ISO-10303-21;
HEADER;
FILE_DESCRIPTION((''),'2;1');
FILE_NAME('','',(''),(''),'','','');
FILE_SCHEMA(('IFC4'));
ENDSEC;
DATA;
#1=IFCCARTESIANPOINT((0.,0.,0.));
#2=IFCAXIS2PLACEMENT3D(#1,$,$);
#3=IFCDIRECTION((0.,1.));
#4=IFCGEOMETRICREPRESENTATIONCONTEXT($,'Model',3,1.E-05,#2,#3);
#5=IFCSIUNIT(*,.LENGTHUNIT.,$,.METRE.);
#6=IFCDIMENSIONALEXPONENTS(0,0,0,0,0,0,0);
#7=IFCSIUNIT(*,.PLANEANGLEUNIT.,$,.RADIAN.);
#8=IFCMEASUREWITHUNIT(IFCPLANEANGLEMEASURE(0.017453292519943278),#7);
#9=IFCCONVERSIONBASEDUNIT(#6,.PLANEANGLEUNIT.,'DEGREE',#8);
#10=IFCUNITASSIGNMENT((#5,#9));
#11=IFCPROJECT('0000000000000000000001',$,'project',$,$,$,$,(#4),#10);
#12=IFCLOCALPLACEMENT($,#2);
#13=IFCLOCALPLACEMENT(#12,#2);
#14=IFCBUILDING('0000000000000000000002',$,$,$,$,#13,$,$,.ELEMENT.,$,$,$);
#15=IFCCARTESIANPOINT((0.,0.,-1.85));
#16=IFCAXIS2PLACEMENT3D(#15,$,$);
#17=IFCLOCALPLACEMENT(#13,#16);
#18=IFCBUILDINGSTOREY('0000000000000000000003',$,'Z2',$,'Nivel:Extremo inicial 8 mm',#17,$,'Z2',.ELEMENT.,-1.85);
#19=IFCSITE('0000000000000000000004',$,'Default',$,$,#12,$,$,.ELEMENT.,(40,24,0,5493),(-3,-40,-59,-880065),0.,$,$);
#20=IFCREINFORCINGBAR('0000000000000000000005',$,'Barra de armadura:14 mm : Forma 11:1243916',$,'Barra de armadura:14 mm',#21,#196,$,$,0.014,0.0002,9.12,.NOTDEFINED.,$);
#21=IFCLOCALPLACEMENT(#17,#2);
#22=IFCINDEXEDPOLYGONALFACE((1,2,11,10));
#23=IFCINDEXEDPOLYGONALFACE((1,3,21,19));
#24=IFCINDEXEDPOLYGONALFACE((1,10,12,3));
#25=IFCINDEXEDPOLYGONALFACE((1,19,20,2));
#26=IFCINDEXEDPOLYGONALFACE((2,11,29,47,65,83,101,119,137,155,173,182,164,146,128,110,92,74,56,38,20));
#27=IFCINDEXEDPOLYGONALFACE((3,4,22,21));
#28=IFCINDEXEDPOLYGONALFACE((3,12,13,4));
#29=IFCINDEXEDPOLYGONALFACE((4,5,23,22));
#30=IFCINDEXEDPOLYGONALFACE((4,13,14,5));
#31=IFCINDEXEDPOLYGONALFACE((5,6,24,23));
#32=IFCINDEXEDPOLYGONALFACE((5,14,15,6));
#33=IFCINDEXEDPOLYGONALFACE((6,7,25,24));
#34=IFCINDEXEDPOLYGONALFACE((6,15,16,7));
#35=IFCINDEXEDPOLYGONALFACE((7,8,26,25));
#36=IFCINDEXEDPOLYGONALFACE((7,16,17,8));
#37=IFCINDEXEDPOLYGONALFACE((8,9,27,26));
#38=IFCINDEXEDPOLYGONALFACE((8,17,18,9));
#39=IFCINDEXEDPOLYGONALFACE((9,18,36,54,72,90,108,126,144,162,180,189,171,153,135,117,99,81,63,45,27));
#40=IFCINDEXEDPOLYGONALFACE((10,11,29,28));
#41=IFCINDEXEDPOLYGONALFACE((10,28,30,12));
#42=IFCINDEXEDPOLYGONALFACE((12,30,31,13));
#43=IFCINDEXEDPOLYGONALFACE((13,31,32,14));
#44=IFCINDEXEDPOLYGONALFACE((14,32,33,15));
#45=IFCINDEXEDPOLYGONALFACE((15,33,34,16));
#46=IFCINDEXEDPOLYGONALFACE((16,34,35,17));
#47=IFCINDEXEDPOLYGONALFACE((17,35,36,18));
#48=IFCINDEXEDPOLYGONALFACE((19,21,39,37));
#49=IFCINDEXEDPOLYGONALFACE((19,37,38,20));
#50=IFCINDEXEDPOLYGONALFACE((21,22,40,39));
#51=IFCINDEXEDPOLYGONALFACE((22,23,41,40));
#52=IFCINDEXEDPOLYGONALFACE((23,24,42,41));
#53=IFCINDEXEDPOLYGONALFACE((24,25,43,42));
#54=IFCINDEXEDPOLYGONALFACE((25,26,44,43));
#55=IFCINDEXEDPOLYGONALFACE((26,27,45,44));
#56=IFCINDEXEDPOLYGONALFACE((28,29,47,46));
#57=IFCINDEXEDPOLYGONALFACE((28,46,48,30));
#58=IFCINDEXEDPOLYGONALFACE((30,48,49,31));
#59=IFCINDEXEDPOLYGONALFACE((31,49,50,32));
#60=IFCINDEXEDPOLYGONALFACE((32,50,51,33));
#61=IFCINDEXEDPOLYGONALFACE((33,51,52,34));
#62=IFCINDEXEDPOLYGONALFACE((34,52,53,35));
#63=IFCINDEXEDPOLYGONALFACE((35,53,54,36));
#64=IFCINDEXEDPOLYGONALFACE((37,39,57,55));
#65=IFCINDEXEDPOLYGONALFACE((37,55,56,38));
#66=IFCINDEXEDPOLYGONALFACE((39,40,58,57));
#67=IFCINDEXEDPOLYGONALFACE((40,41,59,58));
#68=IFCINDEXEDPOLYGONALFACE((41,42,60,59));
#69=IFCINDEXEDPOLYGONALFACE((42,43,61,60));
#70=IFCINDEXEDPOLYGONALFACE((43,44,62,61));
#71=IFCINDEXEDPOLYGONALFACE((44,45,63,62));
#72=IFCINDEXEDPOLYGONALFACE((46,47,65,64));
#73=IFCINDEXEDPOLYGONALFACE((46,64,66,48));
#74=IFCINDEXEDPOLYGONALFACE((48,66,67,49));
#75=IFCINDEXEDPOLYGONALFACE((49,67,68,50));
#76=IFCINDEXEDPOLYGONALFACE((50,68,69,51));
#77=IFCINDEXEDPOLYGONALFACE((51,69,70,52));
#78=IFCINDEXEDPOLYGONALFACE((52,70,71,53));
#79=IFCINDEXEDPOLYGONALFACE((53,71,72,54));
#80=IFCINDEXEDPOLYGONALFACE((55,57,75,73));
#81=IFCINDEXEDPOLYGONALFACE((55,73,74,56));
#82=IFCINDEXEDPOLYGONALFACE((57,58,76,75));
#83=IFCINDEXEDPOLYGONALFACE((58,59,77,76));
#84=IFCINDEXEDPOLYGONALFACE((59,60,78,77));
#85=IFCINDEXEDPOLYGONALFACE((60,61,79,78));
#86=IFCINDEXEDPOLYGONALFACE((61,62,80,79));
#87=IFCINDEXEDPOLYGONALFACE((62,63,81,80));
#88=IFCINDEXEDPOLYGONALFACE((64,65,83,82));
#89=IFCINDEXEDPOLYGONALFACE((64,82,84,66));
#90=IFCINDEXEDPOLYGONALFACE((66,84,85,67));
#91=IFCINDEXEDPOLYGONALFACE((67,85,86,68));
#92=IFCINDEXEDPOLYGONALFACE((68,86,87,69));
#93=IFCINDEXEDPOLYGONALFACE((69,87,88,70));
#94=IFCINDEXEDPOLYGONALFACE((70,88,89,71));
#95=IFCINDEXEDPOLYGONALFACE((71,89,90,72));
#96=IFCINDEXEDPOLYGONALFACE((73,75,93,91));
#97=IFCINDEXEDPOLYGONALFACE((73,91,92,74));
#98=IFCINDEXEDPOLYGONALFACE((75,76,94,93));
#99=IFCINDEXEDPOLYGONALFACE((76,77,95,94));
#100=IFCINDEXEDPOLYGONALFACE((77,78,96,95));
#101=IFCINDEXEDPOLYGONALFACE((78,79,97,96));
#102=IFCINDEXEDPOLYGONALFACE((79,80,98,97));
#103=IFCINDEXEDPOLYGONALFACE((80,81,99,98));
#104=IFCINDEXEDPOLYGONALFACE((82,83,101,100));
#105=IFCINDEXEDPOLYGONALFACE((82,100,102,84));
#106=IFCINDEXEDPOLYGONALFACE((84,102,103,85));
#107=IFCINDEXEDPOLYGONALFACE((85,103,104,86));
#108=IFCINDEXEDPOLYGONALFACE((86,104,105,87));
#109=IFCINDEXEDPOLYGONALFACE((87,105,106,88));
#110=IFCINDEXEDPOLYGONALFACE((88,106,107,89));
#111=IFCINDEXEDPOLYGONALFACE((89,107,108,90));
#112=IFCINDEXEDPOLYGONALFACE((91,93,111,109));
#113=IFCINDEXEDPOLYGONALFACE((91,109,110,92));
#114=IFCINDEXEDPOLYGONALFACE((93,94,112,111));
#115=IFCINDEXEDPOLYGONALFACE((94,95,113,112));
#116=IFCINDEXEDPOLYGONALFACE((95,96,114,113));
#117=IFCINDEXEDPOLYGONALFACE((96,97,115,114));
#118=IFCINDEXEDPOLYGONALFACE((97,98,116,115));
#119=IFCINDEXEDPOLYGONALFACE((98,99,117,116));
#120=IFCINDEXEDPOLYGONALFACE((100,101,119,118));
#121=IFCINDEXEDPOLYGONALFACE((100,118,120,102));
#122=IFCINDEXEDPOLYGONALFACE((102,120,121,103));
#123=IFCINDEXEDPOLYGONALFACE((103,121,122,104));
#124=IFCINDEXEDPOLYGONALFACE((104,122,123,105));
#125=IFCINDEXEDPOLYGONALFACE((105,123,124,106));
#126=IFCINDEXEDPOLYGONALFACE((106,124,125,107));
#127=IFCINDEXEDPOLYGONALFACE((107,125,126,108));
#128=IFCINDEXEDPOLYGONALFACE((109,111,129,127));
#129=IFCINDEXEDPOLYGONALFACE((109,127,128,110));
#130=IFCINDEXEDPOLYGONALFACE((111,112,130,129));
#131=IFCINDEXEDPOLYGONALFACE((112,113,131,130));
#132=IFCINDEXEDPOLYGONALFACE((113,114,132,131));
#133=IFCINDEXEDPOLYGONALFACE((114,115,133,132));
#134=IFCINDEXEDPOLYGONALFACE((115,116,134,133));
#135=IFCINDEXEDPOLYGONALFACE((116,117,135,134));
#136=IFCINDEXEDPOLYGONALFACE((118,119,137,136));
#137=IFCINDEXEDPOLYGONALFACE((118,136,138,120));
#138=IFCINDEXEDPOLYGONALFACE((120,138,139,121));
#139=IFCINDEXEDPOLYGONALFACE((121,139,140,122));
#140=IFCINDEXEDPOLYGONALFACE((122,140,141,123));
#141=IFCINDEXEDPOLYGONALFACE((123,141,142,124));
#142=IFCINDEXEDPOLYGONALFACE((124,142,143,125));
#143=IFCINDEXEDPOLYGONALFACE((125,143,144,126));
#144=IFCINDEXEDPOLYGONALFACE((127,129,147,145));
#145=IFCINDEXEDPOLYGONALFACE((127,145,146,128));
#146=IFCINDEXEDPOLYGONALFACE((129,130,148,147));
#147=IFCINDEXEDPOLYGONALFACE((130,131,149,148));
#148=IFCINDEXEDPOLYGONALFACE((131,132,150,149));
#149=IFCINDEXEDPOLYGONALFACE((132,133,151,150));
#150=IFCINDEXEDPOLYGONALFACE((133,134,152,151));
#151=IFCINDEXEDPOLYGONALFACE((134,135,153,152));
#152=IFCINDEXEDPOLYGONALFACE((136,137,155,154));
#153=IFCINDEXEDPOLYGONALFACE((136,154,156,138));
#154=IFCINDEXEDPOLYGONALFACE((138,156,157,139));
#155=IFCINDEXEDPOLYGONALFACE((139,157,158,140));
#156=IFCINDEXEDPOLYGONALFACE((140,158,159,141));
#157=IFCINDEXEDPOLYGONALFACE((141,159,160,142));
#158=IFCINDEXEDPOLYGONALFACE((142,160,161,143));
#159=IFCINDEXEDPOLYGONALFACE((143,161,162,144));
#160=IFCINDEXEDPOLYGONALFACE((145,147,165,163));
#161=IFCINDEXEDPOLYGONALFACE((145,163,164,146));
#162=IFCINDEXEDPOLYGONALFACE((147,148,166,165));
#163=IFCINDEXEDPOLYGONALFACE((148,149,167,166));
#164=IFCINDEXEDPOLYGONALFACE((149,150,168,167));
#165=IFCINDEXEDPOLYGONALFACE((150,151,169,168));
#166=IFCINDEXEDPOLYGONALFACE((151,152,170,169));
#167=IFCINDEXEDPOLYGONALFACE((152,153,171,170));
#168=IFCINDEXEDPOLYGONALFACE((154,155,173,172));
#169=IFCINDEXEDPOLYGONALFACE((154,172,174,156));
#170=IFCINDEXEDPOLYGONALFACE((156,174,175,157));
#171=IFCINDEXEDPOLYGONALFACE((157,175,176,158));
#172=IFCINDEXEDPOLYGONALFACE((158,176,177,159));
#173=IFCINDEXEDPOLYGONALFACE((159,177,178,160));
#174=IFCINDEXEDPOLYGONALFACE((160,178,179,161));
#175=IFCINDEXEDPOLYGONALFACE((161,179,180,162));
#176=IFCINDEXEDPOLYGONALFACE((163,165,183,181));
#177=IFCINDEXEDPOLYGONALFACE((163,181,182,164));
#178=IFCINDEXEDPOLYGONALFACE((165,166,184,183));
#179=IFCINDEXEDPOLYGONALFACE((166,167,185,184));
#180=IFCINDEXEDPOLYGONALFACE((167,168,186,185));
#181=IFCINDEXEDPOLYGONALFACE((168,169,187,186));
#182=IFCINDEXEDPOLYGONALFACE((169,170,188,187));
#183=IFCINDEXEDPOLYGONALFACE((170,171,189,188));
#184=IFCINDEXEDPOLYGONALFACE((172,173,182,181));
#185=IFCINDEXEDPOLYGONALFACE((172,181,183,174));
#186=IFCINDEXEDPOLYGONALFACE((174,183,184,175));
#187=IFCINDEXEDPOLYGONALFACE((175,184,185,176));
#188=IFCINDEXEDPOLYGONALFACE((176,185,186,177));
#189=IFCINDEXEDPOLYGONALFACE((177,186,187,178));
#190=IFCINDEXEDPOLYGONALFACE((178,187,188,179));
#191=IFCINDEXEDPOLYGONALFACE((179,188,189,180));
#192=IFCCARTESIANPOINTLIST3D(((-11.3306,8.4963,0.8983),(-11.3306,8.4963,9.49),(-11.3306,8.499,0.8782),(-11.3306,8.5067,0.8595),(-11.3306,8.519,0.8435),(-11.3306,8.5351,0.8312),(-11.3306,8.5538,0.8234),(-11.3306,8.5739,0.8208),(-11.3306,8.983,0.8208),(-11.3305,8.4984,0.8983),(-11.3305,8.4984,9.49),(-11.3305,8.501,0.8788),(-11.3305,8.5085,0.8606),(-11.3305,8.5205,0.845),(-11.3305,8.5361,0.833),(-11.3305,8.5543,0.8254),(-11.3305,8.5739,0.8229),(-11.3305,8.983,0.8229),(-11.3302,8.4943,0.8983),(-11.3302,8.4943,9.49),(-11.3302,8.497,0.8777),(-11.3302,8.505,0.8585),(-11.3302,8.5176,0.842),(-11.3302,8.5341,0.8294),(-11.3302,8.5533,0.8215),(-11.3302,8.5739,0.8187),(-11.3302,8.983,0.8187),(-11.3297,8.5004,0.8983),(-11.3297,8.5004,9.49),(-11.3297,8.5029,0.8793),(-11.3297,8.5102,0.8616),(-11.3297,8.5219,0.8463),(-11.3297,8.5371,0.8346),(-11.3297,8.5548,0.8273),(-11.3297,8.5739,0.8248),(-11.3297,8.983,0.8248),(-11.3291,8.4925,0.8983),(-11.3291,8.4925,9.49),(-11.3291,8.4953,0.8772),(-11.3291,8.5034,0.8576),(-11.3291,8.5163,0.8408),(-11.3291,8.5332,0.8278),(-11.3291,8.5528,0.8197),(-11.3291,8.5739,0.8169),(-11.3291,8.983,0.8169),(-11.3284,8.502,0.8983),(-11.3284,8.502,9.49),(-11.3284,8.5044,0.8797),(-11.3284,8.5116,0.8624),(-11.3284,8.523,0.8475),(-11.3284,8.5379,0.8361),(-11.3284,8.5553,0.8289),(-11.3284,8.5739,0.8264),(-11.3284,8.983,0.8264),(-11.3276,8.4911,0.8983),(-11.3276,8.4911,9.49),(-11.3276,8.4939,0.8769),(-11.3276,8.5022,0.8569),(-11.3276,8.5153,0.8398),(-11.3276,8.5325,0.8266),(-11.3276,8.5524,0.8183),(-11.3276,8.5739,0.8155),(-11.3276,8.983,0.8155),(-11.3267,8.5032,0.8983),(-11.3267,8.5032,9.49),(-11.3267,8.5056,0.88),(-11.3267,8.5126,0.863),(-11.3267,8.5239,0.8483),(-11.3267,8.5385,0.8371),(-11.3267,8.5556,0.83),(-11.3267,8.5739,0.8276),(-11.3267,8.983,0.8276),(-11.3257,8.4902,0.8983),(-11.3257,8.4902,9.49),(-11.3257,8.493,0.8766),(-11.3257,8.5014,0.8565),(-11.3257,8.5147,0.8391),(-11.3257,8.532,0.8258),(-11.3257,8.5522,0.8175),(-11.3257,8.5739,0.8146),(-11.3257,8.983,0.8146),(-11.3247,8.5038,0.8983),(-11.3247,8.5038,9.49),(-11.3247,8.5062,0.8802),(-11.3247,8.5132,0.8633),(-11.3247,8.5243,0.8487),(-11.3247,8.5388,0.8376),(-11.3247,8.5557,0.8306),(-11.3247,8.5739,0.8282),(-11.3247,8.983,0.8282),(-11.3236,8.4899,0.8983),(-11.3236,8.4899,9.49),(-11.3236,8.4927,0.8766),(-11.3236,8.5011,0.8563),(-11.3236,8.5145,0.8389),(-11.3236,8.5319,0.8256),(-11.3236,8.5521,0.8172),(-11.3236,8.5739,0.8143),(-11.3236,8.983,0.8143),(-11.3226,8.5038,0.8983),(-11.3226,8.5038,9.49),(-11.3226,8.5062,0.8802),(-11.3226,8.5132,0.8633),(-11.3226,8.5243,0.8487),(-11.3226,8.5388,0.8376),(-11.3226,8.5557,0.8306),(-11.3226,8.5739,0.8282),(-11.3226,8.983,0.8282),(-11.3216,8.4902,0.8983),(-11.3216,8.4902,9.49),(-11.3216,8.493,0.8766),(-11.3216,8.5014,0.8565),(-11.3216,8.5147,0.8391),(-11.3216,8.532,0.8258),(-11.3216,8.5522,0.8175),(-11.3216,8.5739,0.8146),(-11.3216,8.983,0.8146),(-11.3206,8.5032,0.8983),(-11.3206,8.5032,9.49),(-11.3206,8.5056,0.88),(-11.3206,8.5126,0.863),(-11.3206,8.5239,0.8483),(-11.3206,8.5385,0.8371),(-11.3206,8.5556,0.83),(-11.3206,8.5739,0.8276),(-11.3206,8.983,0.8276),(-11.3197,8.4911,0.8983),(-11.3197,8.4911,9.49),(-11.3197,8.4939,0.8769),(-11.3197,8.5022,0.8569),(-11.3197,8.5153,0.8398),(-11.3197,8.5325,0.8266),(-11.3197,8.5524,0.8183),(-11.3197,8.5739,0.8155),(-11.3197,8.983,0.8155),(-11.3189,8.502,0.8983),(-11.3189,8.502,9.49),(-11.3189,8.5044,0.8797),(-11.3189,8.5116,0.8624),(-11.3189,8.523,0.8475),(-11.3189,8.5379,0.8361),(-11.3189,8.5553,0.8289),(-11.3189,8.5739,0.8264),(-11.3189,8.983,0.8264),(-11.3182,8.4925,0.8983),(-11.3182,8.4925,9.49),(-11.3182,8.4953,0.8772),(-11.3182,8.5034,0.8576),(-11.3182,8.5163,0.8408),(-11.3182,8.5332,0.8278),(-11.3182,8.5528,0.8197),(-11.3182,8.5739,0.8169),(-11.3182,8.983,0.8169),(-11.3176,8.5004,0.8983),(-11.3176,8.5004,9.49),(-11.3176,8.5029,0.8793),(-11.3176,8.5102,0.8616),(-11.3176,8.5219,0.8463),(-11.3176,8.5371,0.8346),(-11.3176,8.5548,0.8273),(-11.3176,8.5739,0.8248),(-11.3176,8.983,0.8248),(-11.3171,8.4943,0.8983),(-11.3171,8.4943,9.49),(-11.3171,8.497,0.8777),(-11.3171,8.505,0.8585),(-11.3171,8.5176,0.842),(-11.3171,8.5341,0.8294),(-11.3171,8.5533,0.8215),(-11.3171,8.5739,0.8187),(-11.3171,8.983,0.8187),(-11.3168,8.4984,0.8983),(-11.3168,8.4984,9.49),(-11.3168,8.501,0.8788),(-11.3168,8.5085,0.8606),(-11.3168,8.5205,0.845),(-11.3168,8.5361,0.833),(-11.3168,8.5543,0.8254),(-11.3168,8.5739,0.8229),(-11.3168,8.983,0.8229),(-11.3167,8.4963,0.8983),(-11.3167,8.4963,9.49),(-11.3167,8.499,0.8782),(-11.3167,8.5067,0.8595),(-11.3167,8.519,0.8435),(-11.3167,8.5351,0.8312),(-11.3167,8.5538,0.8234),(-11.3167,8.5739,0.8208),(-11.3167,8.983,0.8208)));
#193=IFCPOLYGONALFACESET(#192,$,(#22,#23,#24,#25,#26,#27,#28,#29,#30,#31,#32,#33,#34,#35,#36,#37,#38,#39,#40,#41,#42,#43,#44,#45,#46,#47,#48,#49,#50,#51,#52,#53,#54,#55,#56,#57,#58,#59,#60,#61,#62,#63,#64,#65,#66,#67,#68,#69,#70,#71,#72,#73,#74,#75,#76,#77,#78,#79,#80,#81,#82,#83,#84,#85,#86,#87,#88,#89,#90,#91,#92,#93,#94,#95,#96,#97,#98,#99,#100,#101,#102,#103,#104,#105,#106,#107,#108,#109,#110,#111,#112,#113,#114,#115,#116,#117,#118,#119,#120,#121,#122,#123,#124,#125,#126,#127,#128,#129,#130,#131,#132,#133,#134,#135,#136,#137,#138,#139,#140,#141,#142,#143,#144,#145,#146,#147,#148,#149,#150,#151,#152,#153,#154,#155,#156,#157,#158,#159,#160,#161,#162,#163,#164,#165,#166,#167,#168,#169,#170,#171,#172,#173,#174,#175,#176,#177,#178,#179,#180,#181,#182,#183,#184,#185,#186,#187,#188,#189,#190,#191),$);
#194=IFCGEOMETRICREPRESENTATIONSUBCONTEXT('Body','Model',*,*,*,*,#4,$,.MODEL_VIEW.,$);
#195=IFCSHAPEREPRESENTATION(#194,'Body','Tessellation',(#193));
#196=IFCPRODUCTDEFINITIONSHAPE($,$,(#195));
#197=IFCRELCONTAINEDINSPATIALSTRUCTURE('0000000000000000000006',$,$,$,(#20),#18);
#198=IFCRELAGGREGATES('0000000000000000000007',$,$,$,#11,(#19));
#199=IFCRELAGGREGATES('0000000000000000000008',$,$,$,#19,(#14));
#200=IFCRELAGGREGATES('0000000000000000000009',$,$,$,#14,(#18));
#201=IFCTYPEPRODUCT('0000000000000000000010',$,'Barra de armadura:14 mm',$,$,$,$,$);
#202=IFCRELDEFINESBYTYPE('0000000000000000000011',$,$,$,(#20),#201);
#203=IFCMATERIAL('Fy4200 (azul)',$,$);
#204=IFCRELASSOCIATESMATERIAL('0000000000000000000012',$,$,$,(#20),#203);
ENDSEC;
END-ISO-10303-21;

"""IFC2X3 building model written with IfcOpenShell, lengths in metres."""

from ifc_helpers import new_model, entity, si_unit, converted_unit, direction, frame, origin, place, context, subcontext, project, spatial, material, type_object, element, save


model = new_model("IFC2X3")

# Units and contexts
model_context = context("Model", 3, precision=1e-05, world=origin(), true_north=direction((0.0, 1.0)))
body_context = subcontext(model_context, "Body", "Model", "MODEL_VIEW")
ifc_project = project(units=[si_unit("LENGTHUNIT", "METRE"), converted_unit("PLANEANGLEUNIT", "DEGREE", entity("IfcPlaneAngleMeasure", 0.017453292519943278), si_unit("PLANEANGLEUNIT", "RADIAN"), dimensions=[0, 0, 0, 0, 0, 0, 0])], contexts=[model_context])

# Site, building, storey
site_placement = place(None, origin())
site = spatial("IfcSite", under=ifc_project, at=site_placement, Name="Default", CompositionType="ELEMENT", RefLatitude=(40, 24, 0, 5493), RefLongitude=(-3, -40, -59, -880065), RefElevation=0.0)
building_placement = place(site_placement, origin())
building = spatial("IfcBuilding", under=site, at=building_placement, CompositionType="ELEMENT")
storey_placement = place(building_placement, frame((0.0, 0.0, -1.85)))
storey = spatial("IfcBuildingStorey", under=building, at=storey_placement, Name="Z2", ObjectType="Nivel:Extremo inicial 8 mm", LongName="Z2", CompositionType="ELEMENT", Elevation=-1.85)

# Reinforcing bar
ifc_material_1 = material(Name="Fy4200 (azul)")
type_product_1 = type_object("IfcTypeProduct", Name="Barra de armadura:14 mm")
reinforcing_bar_1_placement = place(storey_placement, origin())
element("IfcReinforcingBar", 1, at=reinforcing_bar_1_placement, inside=storey, type_object=type_product_1, material=ifc_material_1, Name="Barra de armadura:14 mm : Forma 11:1243916", ObjectType="Barra de armadura:14 mm", BarLength=9.12, BarRole="NOTDEFINED", CrossSectionArea=0.0002, NominalDiameter=0.014, context=body_context, shape_type="AdvancedSweptSolid", body=[
    entity("IfcSweptDiskSolid", entity("IfcCompositeCurve", [entity("IfcCompositeCurveSegment", "CONTINUOUS", True, entity("IfcPolyline", [entity("IfcCartesianPoint", [-11.3236, 8.4969, 9.49]), entity("IfcCartesianPoint", [-11.3236, 8.4969, 0.8983])])), entity("IfcCompositeCurveSegment", "CONTINUOUS", True, entity("IfcTrimmedCurve", entity("IfcCircle", entity("IfcAxis2Placement3D", entity("IfcCartesianPoint", [-11.3236, 8.5739, 0.8983]), entity("IfcDirection", [1.0, 0.0, 0.0]), entity("IfcDirection", [0.0, 0.0, -1.0])), 0.077), [entity("IfcParameterValue", 270.0)], [entity("IfcParameterValue", 360.0)], True, "PARAMETER")), entity("IfcCompositeCurveSegment", "CONTINUOUS", True, entity("IfcPolyline", [entity("IfcCartesianPoint", [-11.3236, 8.5739, 0.8213]), entity("IfcCartesianPoint", [-11.3236, 8.983, 0.8213])]))], False), 0.007, None, 0.0, 92.0),
])

save(model, "model.ifc")
